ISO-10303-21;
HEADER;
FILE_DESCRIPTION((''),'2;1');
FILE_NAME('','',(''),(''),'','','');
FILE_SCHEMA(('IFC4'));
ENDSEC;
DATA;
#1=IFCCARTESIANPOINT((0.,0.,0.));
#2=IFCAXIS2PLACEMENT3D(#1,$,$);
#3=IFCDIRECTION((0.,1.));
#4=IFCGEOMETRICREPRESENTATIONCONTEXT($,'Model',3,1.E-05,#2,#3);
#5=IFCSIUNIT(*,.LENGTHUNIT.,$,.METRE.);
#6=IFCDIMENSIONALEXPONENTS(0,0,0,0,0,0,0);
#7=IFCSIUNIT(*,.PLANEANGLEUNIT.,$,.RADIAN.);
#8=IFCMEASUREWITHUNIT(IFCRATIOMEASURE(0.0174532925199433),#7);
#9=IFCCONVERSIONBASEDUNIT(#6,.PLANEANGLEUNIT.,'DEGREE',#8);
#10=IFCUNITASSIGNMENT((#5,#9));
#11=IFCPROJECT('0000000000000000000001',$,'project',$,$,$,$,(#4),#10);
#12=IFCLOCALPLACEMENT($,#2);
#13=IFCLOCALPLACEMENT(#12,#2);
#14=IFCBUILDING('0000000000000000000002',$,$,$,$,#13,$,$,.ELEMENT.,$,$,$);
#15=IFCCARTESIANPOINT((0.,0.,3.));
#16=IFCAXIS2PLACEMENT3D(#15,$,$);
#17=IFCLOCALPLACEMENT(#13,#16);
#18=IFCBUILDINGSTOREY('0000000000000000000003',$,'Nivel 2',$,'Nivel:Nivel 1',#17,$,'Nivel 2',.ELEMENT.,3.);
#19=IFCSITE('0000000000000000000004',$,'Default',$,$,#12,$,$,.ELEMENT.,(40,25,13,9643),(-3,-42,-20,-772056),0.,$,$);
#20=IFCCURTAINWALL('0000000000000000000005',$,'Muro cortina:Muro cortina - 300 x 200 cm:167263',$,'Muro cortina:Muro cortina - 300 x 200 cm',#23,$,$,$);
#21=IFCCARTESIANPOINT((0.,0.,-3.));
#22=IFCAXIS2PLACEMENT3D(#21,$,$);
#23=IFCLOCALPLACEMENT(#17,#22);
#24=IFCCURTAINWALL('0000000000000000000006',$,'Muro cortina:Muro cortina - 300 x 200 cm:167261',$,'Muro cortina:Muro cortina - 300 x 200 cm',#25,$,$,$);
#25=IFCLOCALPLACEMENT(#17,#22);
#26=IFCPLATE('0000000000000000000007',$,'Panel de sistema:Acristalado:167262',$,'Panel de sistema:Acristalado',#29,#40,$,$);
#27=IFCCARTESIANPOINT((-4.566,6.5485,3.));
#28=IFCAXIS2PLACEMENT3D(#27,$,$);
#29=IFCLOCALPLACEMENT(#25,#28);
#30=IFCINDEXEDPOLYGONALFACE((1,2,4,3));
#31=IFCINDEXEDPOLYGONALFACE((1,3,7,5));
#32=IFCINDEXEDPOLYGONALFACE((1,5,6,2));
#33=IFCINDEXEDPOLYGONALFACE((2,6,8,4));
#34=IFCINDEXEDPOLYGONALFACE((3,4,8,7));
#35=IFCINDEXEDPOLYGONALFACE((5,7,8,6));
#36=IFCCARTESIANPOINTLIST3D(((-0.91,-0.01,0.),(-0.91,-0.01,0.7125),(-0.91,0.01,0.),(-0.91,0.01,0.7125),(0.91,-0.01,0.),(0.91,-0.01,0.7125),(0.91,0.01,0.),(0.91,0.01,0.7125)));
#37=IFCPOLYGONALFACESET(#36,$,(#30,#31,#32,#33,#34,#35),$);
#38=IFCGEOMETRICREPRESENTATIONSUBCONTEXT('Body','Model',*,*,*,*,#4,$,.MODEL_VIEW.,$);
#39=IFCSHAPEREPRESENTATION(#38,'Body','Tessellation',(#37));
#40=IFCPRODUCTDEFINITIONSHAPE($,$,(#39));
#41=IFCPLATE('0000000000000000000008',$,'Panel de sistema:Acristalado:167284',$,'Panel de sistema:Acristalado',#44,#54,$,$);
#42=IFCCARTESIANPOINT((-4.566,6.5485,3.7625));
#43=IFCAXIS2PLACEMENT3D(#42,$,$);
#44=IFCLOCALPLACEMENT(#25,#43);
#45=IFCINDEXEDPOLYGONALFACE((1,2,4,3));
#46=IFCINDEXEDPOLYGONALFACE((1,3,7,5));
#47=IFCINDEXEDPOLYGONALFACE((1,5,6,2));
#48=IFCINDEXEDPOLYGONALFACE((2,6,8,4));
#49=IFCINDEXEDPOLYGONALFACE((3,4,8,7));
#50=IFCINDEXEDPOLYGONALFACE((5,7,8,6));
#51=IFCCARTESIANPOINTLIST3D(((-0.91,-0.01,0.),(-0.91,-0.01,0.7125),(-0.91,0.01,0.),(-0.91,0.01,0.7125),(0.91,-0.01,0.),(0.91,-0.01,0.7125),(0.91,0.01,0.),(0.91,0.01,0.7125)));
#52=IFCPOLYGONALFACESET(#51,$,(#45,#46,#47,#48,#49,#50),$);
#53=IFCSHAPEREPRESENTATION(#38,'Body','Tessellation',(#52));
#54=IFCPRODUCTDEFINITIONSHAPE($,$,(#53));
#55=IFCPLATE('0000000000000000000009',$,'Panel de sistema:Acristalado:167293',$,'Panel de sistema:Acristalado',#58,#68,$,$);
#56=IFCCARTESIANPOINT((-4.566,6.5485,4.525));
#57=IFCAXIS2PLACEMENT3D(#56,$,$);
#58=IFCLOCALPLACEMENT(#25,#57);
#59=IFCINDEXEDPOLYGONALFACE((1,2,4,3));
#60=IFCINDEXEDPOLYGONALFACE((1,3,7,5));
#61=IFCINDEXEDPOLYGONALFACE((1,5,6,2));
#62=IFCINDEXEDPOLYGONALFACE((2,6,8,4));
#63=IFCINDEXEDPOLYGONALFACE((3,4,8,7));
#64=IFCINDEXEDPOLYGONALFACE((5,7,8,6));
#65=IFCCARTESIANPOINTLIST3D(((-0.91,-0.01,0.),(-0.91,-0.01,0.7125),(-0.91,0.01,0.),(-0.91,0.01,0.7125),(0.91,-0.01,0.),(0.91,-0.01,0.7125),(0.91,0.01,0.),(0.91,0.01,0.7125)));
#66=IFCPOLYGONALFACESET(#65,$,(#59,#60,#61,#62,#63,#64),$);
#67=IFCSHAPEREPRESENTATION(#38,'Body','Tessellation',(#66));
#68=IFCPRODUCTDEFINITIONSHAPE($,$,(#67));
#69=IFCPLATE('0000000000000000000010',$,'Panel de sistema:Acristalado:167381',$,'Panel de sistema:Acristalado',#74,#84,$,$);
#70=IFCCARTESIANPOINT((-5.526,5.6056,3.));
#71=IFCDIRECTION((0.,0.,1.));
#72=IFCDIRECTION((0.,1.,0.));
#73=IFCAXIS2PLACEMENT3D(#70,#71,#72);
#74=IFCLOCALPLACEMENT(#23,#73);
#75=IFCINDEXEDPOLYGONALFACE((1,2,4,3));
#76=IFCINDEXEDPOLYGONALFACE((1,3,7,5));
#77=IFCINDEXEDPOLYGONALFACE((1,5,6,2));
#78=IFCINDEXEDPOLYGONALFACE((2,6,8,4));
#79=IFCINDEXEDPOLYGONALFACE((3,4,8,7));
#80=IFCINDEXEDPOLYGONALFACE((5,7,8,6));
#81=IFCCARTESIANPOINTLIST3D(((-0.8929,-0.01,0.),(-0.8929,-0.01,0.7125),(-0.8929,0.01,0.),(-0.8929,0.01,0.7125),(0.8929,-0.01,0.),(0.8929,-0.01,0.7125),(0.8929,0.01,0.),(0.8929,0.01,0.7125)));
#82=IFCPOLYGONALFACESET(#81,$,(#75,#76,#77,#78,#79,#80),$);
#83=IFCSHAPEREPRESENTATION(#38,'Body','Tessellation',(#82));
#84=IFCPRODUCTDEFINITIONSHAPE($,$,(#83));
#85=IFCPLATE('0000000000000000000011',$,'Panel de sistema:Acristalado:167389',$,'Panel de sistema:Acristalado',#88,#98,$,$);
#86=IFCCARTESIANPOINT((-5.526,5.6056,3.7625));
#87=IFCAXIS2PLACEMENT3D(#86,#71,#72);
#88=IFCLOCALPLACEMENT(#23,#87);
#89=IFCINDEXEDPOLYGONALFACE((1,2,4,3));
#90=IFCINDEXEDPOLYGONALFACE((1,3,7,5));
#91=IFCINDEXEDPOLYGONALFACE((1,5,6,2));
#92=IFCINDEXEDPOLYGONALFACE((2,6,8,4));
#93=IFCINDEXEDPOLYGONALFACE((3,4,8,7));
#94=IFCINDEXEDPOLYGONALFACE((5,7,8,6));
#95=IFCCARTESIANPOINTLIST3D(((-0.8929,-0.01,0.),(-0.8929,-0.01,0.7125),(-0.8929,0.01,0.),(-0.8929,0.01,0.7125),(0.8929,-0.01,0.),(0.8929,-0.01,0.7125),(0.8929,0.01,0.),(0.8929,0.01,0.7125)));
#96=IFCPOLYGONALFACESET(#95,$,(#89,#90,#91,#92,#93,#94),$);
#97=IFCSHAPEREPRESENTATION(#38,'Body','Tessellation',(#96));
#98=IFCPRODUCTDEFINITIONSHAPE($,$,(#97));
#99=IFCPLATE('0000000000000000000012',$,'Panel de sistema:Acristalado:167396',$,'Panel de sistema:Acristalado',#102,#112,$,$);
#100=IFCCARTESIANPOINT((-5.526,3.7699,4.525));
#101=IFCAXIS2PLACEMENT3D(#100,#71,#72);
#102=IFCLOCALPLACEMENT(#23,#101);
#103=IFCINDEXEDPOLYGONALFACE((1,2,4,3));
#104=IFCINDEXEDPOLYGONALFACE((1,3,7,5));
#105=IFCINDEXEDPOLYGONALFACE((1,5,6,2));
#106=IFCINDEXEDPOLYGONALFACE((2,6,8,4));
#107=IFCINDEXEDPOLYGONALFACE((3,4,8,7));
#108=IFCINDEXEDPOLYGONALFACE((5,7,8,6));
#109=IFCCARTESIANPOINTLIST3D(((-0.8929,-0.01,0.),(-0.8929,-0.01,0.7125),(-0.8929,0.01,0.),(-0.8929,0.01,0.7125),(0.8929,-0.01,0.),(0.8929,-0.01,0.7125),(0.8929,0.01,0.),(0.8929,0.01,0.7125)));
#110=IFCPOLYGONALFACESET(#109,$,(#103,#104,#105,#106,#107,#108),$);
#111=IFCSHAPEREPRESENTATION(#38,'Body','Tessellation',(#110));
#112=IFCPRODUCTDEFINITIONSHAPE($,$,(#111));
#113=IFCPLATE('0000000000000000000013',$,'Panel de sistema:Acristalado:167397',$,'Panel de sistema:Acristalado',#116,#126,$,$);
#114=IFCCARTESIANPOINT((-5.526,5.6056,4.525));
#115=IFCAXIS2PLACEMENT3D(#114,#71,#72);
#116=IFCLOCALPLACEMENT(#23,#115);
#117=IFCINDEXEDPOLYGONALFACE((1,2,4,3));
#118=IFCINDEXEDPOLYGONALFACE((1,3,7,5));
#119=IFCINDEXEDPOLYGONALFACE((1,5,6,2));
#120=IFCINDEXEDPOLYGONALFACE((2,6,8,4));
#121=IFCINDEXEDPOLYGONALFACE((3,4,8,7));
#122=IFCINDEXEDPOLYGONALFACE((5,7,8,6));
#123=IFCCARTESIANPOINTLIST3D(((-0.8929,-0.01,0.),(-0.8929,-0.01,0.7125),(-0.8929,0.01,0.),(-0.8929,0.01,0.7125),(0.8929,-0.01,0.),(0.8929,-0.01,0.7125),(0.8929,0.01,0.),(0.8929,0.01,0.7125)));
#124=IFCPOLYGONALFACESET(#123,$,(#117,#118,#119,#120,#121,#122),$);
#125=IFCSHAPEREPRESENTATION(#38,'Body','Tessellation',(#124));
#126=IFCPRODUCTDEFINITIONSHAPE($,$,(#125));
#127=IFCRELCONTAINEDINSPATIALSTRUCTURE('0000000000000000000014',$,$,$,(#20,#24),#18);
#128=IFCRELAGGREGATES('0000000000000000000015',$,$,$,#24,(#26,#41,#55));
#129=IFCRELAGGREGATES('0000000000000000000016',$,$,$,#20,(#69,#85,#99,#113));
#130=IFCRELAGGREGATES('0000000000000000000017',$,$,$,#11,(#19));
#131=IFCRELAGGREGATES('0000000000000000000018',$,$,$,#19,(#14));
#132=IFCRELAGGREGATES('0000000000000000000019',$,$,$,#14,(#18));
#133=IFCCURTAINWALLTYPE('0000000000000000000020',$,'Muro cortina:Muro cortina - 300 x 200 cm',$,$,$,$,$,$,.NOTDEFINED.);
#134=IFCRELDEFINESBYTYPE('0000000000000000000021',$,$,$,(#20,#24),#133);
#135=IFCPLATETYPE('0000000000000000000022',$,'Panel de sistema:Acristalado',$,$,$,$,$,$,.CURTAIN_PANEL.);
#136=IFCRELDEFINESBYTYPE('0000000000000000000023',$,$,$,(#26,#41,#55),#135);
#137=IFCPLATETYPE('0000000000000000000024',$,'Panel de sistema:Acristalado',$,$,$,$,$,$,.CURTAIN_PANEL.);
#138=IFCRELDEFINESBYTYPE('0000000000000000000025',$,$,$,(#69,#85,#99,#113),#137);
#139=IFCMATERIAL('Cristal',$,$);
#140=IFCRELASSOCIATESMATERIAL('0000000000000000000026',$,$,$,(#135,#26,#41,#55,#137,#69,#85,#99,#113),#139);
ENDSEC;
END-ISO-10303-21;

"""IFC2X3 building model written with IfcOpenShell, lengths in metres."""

from ifc_helpers import new_model, entity, si_unit, converted_unit, direction, frame, origin, origin_2d_with_axis, place, context, subcontext, project, spatial, rectangle, extrude, source, transform, mapped, material, type_object, type_shapes, element, aggregate, save


model = new_model("IFC2X3")

# Units and contexts
model_context = context("Model", 3, precision=1e-05, world=origin(), true_north=direction((0.0, 1.0)))
body_context = subcontext(model_context, "Body", "Model", "MODEL_VIEW")
ifc_project = project(units=[si_unit("LENGTHUNIT", "METRE"), converted_unit("PLANEANGLEUNIT", "DEGREE", entity("IfcRatioMeasure", 0.0174532925199433), si_unit("PLANEANGLEUNIT", "RADIAN"), dimensions=[0, 0, 0, 0, 0, 0, 0])], contexts=[model_context])

# Site, building, storey
site_placement = place(None, origin())
site = spatial("IfcSite", under=ifc_project, at=site_placement, Name="Default", CompositionType="ELEMENT", RefLatitude=(40, 25, 13, 9643), RefLongitude=(-3, -42, -20, -772056), RefElevation=0.0)
building_placement = place(site_placement, origin())
building = spatial("IfcBuilding", under=site, at=building_placement, CompositionType="ELEMENT")
storey_placement = place(building_placement, frame((0.0, 0.0, 3.0)))
storey = spatial("IfcBuildingStorey", under=building, at=storey_placement, Name="Nivel 2", ObjectType="Nivel:Nivel 1", LongName="Nivel 2", CompositionType="ELEMENT", Elevation=3.0)

# Curtain walls
curtain_wall_type = type_object("IfcCurtainWallType", Name="Muro cortina:Muro cortina - 300 x 200 cm", PredefinedType="NOTDEFINED")
curtain_wall_1_placement = place(storey_placement, frame((0.0, 0.0, -3.0)))
curtain_wall_1 = element("IfcCurtainWall", 1, at=curtain_wall_1_placement, inside=storey, type_object=curtain_wall_type, Name="Muro cortina:Muro cortina - 300 x 200 cm:167263", ObjectType="Muro cortina:Muro cortina - 300 x 200 cm")
curtain_wall_2_placement = place(storey_placement, frame((0.0, 0.0, -3.0)))
curtain_wall_2 = element("IfcCurtainWall", 2, at=curtain_wall_2_placement, inside=storey, type_object=curtain_wall_type, Name="Muro cortina:Muro cortina - 300 x 200 cm:167261", ObjectType="Muro cortina:Muro cortina - 300 x 200 cm")

# Plates
ifc_material_1 = material(Name="Cristal")
plate_type_1 = type_object("IfcPlateType", Name="Panel de sistema:Acristalado", PredefinedType="CURTAIN_PANEL", material=ifc_material_1)
shared_shape_1 = source(origin(), body_context, "Body", "SweptSolid", [
    extrude(rectangle(XDim=0.02, YDim=1.82, at=origin_2d_with_axis()), frame((0.0, 0.0, 0.0), z_axis=(0.0, 0.0, 1.0), x_axis=(0.0, 1.0, 0.0)), (0.0, 0.0, 1.0), 0.7125),
])
type_shapes(plate_type_1, [shared_shape_1])
plate_1_placement = place(curtain_wall_2_placement, frame((-4.566, 6.5485, 3.0)))
plate_1 = element("IfcPlate", 3, at=plate_1_placement, type_object=plate_type_1, material=ifc_material_1, Name="Panel de sistema:Acristalado:167262", ObjectType="Panel de sistema:Acristalado", context=body_context, shape_type="MappedRepresentation", body=[
    mapped(shared_shape_1, transform((0.0, 0.0, 0.0), scale=1.0)),
])
plate_2_placement = place(curtain_wall_2_placement, frame((-4.566, 6.5485, 3.7625)))
plate_2 = element("IfcPlate", 4, at=plate_2_placement, type_object=plate_type_1, material=ifc_material_1, Name="Panel de sistema:Acristalado:167284", ObjectType="Panel de sistema:Acristalado", context=body_context, shape_type="MappedRepresentation", body=[
    mapped(shared_shape_1, transform((0.0, 0.0, 0.0), scale=1.0)),
])
plate_3_placement = place(curtain_wall_2_placement, frame((-4.566, 6.5485, 4.525)))
plate_3 = element("IfcPlate", 5, at=plate_3_placement, type_object=plate_type_1, material=ifc_material_1, Name="Panel de sistema:Acristalado:167293", ObjectType="Panel de sistema:Acristalado", context=body_context, shape_type="MappedRepresentation", body=[
    mapped(shared_shape_1, transform((0.0, 0.0, 0.0), scale=1.0)),
])
aggregate(curtain_wall_2, [plate_1, plate_2, plate_3])
plate_type_2 = type_object("IfcPlateType", Name="Panel de sistema:Acristalado", PredefinedType="CURTAIN_PANEL", material=ifc_material_1)
shared_shape_2 = source(origin(), body_context, "Body", "SweptSolid", [
    extrude(rectangle(XDim=0.02, YDim=1.7857, at=origin_2d_with_axis()), frame((0.0, 0.0, 0.0), z_axis=(0.0, 0.0, 1.0), x_axis=(0.0, 1.0, 0.0)), (0.0, 0.0, 1.0), 0.7125),
])
type_shapes(plate_type_2, [shared_shape_2])
plate_4_placement = place(curtain_wall_1_placement, frame((-5.526, 5.6056, 3.0), z_axis=(0.0, 0.0, 1.0), x_axis=(0.0, 1.0, 0.0)))
plate_4 = element("IfcPlate", 6, at=plate_4_placement, type_object=plate_type_2, material=ifc_material_1, Name="Panel de sistema:Acristalado:167381", ObjectType="Panel de sistema:Acristalado", context=body_context, shape_type="MappedRepresentation", body=[
    mapped(shared_shape_2, transform((0.0, 0.0, 0.0), scale=1.0)),
])
plate_5_placement = place(curtain_wall_1_placement, frame((-5.526, 5.6056, 3.7625), z_axis=(0.0, 0.0, 1.0), x_axis=(0.0, 1.0, 0.0)))
plate_5 = element("IfcPlate", 7, at=plate_5_placement, type_object=plate_type_2, material=ifc_material_1, Name="Panel de sistema:Acristalado:167389", ObjectType="Panel de sistema:Acristalado", context=body_context, shape_type="MappedRepresentation", body=[
    mapped(shared_shape_2, transform((0.0, 0.0, 0.0), scale=1.0)),
])
plate_6_placement = place(curtain_wall_1_placement, frame((-5.526, 3.7699, 4.525), z_axis=(0.0, 0.0, 1.0), x_axis=(0.0, 1.0, 0.0)))
plate_6 = element("IfcPlate", 8, at=plate_6_placement, type_object=plate_type_2, material=ifc_material_1, Name="Panel de sistema:Acristalado:167396", ObjectType="Panel de sistema:Acristalado", context=body_context, shape_type="MappedRepresentation", body=[
    mapped(shared_shape_2, transform((0.0, 0.0, 0.0), scale=1.0)),
])
plate_7_placement = place(curtain_wall_1_placement, frame((-5.526, 5.6056, 4.525), z_axis=(0.0, 0.0, 1.0), x_axis=(0.0, 1.0, 0.0)))
plate_7 = element("IfcPlate", 9, at=plate_7_placement, type_object=plate_type_2, material=ifc_material_1, Name="Panel de sistema:Acristalado:167397", ObjectType="Panel de sistema:Acristalado", context=body_context, shape_type="MappedRepresentation", body=[
    mapped(shared_shape_2, transform((0.0, 0.0, 0.0), scale=1.0)),
])
aggregate(curtain_wall_1, [plate_4, plate_5, plate_6, plate_7])

save(model, "model.ifc")
